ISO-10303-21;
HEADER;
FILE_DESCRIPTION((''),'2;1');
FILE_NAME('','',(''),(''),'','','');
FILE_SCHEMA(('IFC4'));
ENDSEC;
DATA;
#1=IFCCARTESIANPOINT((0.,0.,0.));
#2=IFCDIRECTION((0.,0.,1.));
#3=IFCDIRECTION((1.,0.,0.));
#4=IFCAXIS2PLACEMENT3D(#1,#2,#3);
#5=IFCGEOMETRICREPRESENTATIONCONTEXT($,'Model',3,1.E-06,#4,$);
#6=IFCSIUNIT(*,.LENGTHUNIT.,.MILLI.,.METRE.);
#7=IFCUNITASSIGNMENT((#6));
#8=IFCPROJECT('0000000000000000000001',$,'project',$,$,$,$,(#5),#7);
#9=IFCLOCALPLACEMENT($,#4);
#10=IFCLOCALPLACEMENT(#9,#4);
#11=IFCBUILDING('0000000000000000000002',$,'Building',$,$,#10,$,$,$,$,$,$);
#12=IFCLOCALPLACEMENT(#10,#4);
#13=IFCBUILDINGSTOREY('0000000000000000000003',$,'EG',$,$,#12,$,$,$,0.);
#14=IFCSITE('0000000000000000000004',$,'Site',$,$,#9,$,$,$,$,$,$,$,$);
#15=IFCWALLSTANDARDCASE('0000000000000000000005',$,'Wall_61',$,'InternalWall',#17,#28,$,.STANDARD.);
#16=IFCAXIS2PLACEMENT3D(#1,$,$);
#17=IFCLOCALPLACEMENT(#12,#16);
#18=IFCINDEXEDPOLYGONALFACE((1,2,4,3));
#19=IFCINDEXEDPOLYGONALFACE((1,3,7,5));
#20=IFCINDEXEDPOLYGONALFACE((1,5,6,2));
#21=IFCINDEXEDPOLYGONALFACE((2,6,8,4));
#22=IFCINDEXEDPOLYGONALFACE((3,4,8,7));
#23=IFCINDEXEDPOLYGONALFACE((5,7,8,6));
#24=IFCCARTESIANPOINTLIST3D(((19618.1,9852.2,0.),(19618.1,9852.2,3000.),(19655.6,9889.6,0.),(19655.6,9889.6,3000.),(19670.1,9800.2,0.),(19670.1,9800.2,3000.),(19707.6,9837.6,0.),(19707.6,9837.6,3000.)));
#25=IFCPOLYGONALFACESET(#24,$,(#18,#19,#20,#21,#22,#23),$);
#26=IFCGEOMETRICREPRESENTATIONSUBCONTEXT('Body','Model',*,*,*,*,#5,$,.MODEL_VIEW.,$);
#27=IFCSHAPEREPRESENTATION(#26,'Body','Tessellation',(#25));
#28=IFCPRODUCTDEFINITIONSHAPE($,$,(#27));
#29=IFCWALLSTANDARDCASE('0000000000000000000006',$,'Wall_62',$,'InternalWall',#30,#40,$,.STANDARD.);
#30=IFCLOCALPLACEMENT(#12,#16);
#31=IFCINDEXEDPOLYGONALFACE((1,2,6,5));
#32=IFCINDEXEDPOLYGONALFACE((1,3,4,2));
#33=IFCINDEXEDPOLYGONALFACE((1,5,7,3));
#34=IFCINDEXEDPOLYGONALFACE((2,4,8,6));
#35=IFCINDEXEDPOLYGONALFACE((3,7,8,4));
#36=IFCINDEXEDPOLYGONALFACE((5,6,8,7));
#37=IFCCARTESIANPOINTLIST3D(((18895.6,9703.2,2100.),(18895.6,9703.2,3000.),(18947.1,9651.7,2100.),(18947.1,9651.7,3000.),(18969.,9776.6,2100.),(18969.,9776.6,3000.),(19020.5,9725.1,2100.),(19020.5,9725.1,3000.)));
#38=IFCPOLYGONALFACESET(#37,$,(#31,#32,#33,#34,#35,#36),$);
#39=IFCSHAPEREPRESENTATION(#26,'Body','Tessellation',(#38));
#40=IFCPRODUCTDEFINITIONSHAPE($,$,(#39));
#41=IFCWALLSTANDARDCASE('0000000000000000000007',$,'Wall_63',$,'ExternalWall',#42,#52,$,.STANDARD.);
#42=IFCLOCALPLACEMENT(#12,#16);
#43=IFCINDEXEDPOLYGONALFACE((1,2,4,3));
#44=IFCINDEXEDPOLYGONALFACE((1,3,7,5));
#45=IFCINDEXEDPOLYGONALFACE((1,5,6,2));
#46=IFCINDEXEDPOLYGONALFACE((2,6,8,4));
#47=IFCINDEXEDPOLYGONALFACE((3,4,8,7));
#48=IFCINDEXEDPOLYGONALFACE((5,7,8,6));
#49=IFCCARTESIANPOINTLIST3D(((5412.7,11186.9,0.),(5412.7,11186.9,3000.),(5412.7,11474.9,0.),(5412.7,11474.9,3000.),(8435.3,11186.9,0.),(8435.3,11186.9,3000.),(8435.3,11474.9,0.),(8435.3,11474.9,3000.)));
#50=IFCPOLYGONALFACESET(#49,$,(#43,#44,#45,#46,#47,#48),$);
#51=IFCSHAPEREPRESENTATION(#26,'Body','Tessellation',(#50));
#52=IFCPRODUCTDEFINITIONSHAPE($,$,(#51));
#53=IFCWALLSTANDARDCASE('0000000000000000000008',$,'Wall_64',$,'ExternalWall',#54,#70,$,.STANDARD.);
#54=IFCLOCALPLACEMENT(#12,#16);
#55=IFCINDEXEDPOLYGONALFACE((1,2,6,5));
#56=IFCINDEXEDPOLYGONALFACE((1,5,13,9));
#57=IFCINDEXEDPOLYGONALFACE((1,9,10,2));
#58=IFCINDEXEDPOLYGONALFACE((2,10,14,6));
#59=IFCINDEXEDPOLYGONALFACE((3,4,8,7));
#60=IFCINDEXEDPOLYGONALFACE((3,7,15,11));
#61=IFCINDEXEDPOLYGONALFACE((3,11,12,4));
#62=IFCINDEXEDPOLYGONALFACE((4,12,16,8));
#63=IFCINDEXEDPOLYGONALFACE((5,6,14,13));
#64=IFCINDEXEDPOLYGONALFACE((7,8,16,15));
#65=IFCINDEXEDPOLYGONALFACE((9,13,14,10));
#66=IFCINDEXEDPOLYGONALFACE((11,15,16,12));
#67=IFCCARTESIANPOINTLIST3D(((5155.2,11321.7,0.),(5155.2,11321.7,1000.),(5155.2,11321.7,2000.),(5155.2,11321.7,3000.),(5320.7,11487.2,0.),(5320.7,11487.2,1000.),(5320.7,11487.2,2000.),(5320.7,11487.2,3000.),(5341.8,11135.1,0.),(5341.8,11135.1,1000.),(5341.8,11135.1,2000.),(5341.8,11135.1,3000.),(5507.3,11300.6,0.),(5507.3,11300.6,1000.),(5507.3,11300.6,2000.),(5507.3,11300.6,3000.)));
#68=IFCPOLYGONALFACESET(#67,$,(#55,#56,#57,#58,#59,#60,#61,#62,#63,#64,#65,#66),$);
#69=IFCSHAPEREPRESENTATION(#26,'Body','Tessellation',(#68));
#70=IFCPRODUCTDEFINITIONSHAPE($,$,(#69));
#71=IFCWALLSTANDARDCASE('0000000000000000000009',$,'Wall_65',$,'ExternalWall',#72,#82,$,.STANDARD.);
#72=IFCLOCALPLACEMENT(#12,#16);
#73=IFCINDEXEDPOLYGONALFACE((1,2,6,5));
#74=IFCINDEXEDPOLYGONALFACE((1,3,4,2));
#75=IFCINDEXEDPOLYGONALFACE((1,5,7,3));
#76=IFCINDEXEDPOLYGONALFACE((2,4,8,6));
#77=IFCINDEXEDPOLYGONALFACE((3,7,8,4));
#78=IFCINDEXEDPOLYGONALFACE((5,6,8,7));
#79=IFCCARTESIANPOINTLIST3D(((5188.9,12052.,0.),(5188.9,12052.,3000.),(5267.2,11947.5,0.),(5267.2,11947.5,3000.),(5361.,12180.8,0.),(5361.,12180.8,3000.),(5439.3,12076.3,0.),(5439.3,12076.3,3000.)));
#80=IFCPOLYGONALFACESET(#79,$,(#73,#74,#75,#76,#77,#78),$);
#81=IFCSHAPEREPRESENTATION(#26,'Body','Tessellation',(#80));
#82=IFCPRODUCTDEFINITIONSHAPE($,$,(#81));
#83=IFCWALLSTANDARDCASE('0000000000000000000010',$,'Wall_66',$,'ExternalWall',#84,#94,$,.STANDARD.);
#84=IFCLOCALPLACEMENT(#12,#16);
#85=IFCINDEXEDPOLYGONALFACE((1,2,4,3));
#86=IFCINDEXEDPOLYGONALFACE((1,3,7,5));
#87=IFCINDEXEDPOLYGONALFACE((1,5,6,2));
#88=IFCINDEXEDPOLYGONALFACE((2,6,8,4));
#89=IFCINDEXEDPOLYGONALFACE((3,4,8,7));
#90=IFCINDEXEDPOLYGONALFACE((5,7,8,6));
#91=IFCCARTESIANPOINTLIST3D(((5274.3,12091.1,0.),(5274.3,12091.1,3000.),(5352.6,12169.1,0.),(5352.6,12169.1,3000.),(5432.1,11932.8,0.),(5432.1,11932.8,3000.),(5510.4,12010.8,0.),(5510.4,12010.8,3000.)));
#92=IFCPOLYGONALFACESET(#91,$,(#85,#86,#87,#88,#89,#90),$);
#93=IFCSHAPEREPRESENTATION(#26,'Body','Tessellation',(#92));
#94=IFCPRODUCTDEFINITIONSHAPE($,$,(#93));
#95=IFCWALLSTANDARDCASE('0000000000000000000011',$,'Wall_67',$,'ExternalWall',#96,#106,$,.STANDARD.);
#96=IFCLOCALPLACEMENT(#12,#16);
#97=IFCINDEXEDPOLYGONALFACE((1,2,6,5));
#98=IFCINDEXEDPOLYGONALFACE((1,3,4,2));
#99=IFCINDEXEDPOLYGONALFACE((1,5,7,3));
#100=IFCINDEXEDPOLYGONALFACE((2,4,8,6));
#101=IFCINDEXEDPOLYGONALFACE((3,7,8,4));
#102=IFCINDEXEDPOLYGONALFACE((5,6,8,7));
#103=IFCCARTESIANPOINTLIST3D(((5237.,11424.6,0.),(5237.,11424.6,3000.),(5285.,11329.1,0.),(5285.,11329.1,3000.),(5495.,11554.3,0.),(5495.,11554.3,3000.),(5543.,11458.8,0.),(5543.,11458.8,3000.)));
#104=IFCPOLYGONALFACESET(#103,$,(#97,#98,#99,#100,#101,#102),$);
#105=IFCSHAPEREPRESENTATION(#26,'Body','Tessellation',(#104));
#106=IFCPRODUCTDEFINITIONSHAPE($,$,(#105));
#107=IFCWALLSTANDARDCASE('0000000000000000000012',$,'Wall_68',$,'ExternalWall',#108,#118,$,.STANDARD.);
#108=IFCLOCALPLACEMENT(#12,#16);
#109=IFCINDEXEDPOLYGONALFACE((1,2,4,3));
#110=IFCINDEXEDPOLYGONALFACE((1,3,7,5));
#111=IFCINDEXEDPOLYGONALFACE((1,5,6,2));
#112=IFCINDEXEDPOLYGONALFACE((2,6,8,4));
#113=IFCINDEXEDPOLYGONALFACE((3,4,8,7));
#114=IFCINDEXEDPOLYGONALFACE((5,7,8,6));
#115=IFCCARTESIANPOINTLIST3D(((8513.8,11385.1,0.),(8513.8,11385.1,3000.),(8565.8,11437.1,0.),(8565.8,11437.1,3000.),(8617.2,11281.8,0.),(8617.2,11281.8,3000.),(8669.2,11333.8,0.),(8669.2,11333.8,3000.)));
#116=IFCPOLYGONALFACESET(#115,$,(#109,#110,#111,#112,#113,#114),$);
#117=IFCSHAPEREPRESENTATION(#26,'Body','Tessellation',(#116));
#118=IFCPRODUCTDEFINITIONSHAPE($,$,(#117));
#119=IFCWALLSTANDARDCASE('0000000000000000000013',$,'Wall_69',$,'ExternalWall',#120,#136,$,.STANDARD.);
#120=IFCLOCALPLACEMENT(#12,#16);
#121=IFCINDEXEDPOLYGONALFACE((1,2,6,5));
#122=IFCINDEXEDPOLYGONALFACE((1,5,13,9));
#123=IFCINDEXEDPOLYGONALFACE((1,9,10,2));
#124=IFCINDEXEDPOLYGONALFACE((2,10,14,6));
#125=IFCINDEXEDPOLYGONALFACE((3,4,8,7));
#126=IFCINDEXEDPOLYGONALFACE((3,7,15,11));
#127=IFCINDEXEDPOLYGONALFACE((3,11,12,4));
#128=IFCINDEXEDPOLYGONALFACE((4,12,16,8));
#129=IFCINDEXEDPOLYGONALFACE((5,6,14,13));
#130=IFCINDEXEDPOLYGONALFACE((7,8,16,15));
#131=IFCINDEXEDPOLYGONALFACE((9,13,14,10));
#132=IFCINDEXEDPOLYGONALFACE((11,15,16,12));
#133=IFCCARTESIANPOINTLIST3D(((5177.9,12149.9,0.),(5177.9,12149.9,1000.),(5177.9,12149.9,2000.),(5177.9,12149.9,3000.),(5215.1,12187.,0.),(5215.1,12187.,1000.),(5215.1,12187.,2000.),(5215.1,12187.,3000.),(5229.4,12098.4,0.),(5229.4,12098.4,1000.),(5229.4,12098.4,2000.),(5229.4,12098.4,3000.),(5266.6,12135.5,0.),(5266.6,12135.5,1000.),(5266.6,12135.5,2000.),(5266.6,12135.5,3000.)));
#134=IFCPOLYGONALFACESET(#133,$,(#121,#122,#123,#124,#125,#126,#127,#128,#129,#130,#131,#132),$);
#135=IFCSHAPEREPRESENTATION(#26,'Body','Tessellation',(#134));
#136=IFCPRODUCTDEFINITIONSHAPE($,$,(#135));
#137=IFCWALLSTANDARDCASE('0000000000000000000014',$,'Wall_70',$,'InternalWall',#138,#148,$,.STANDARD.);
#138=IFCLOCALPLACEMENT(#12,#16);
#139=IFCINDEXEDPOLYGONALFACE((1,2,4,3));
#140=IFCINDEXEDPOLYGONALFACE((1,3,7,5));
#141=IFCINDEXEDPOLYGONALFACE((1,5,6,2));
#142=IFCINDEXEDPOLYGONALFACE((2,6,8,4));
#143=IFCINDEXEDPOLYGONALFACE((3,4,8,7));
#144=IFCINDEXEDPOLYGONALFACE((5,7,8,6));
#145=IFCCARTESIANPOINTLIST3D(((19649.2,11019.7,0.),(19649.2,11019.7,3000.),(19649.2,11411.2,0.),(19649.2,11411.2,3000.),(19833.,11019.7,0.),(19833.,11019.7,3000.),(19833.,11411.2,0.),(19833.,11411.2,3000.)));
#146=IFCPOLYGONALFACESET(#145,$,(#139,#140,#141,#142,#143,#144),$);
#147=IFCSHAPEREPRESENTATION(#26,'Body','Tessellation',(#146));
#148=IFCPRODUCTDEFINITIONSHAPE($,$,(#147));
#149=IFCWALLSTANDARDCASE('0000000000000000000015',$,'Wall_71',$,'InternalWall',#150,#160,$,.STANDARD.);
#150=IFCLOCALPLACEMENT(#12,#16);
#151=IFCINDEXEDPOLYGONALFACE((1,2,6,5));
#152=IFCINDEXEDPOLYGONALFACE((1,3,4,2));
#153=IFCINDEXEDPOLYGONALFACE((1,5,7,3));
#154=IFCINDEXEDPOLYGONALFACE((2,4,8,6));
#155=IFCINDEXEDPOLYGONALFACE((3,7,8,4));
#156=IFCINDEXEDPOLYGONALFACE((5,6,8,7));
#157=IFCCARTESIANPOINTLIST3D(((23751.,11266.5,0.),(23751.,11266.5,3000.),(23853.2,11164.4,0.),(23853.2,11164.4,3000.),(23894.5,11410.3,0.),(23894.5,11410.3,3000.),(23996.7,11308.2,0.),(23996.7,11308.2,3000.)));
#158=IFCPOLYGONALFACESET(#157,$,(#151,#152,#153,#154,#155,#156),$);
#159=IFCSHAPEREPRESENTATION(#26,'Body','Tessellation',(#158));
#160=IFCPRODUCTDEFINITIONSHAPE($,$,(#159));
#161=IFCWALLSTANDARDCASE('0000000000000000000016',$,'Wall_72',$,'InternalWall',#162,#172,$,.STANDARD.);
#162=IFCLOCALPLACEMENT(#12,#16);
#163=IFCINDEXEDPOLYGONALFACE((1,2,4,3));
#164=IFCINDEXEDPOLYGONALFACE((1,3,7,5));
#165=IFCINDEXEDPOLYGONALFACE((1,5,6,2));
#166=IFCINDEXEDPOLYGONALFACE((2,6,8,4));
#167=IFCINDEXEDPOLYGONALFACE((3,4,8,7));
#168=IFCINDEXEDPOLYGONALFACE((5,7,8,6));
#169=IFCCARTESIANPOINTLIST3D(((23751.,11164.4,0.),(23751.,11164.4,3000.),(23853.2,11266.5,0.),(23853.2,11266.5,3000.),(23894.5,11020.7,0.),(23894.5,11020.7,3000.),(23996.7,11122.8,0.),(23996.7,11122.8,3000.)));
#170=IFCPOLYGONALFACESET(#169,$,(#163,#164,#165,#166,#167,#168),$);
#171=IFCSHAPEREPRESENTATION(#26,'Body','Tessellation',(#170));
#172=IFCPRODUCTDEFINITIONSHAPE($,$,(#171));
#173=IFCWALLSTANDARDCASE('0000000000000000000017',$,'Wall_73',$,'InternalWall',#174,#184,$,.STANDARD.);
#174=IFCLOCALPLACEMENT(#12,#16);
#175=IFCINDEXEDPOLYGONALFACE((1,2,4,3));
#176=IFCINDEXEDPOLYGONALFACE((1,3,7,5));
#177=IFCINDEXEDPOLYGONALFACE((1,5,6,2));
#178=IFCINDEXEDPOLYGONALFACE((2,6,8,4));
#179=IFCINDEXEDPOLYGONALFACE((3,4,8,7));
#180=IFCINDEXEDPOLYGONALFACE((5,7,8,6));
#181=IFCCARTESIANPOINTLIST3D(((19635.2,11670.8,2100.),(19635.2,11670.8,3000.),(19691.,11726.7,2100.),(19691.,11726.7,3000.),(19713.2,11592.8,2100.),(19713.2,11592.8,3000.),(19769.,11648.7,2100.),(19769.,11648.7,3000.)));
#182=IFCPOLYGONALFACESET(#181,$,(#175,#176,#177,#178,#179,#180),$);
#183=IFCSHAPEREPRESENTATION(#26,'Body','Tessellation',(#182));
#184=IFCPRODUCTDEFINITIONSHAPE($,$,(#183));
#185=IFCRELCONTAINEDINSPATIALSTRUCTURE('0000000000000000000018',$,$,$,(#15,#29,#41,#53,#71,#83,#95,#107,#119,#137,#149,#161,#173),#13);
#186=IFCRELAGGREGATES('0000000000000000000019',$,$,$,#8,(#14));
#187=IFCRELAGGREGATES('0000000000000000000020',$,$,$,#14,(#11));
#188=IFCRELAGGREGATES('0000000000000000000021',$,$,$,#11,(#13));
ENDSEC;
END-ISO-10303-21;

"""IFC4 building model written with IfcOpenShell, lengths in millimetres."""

from ifc_helpers import new_model, si_unit, frame, origin_with_axes, place, context, subcontext, project, spatial, rectangle, extrude, element, save


model = new_model("IFC4")

# Units and contexts
model_context = context("Model", 3, precision=1e-06, world=origin_with_axes())
body_context = subcontext(model_context, "Body", "Model", "MODEL_VIEW")
ifc_project = project(units=[si_unit("LENGTHUNIT", "METRE", prefix="MILLI")], contexts=[model_context])

# Site, building, storey
site_placement = place(None, origin_with_axes())
site = spatial("IfcSite", under=ifc_project, at=site_placement, Name="Site")
building_placement = place(site_placement, origin_with_axes())
building = spatial("IfcBuilding", under=site, at=building_placement, Name="Building")
storey_placement = place(building_placement, origin_with_axes())
storey = spatial("IfcBuildingStorey", under=building, at=storey_placement, Name="EG", Elevation=0.0)

# Wall
wall_1_placement = place(storey_placement, origin_with_axes())
element("IfcWallStandardCase", 1, at=wall_1_placement, inside=storey, Name="Wall_61", ObjectType="InternalWall", PredefinedType="STANDARD", context=body_context, shape_type="SweptSolid", body=[
    extrude(rectangle(XDim=73.5, YDim=53.0), frame((19662.8, 9844.9, 0.0), z_axis=(0.0, 0.0, 1.0), x_axis=(0.707107, -0.707107, 0.0)), (0.0, 0.0, 1.0), 3000.0),
])

# Wall, opening
wall_2_placement = place(storey_placement, origin_with_axes())
wall_2 = element("IfcWallStandardCase", 2, at=wall_2_placement, inside=storey, Name="Wall_62", ObjectType="InternalWall", PredefinedType="STANDARD", context=body_context, shape_type="SweptSolid", body=[
    extrude(rectangle(XDim=72.8, YDim=103.8), frame((18958.1, 9714.2, 0.0), z_axis=(0.0, 0.0, 1.0), x_axis=(0.707107, -0.707107, 0.0)), (0.0, 0.0, 1.0), 3000.0),
])
opening_1_placement = place(wall_2_placement, origin_with_axes())
element("IfcOpeningElement", 3, at=opening_1_placement, inside=storey, cuts=wall_2, context=body_context, shape_type="SweptSolid", body=[
    extrude(rectangle(XDim=450.0, YDim=103.8), frame((18958.1, 9714.2, 0.0), z_axis=(0.0, 0.0, 1.0), x_axis=(0.707107, -0.707107, 0.0)), (0.0, 0.0, 1.0), 2100.0),
])

# Wall
wall_3_placement = place(storey_placement, origin_with_axes())
element("IfcWallStandardCase", 4, at=wall_3_placement, inside=storey, Name="Wall_63", ObjectType="ExternalWall", PredefinedType="STANDARD", context=body_context, shape_type="SweptSolid", body=[
    extrude(rectangle(XDim=3022.6, YDim=288.0), frame((6924.0, 11330.9, 0.0), z_axis=(0.0, 0.0, 1.0), x_axis=(1.0, 0.0, 0.0)), (0.0, 0.0, 1.0), 3000.0),
])

# Wall, opening
wall_4_placement = place(storey_placement, origin_with_axes())
wall_4 = element("IfcWallStandardCase", 5, at=wall_4_placement, inside=storey, Name="Wall_64", ObjectType="ExternalWall", PredefinedType="STANDARD", context=body_context, shape_type="SweptSolid", body=[
    extrude(rectangle(XDim=234.1, YDim=263.9), frame((5331.2, 11311.2, 0.0), z_axis=(0.0, 0.0, 1.0), x_axis=(-0.707107, -0.707107, 0.0)), (0.0, 0.0, 1.0), 3000.0),
])
opening_2_placement = place(wall_4_placement, origin_with_axes())
element("IfcOpeningElement", 6, at=opening_2_placement, inside=storey, cuts=wall_4, context=body_context, shape_type="SweptSolid", body=[
    extrude(rectangle(XDim=600.0, YDim=263.9), frame((5268.2, 11248.1, 1000.0), z_axis=(0.0, 0.0, 1.0), x_axis=(-0.707107, -0.707107, 0.0)), (0.0, 0.0, 1.0), 1000.0),
])

# Walls
wall_5_placement = place(storey_placement, origin_with_axes())
element("IfcWallStandardCase", 7, at=wall_5_placement, inside=storey, Name="Wall_65", ObjectType="ExternalWall", PredefinedType="STANDARD", context=body_context, shape_type="SweptSolid", body=[
    extrude(rectangle(XDim=130.6, YDim=215.0), frame((5314.1, 12064.2, 0.0), z_axis=(0.0, 0.0, 1.0), x_axis=(-0.599387, 0.800459, 0.0)), (0.0, 0.0, 1.0), 3000.0),
])
wall_6_placement = place(storey_placement, origin_with_axes())
element("IfcWallStandardCase", 8, at=wall_6_placement, inside=storey, Name="Wall_66", ObjectType="ExternalWall", PredefinedType="STANDARD", context=body_context, shape_type="SweptSolid", body=[
    extrude(rectangle(XDim=110.5, YDim=223.5), frame((5392.4, 12050.9, 0.0), z_axis=(0.0, 0.0, 1.0), x_axis=(0.708237, 0.705975, 0.0)), (0.0, 0.0, 1.0), 3000.0),
])
wall_7_placement = place(storey_placement, origin_with_axes())
element("IfcWallStandardCase", 9, at=wall_7_placement, inside=storey, Name="Wall_67", ObjectType="ExternalWall", PredefinedType="STANDARD", context=body_context, shape_type="SweptSolid", body=[
    extrude(rectangle(XDim=106.9, YDim=288.8), frame((5390.0, 11441.7, 0.0), z_axis=(0.0, 0.0, 1.0), x_axis=(0.449084, -0.89349, 0.0)), (0.0, 0.0, 1.0), 3000.0),
])
wall_8_placement = place(storey_placement, origin_with_axes())
element("IfcWallStandardCase", 10, at=wall_8_placement, inside=storey, Name="Wall_68", ObjectType="ExternalWall", PredefinedType="STANDARD", context=body_context, shape_type="SweptSolid", body=[
    extrude(rectangle(XDim=73.5, YDim=146.1), frame((8591.5, 11359.4, 0.0), z_axis=(0.0, 0.0, 1.0), x_axis=(-0.707107, -0.707107, 0.0)), (0.0, 0.0, 1.0), 3000.0),
])

# Wall, opening
wall_9_placement = place(storey_placement, origin_with_axes())
wall_9 = element("IfcWallStandardCase", 11, at=wall_9_placement, inside=storey, Name="Wall_69", ObjectType="ExternalWall", PredefinedType="STANDARD", context=body_context, shape_type="SweptSolid", body=[
    extrude(rectangle(XDim=72.8, YDim=52.5), frame((5222.2, 12142.7, 0.0), z_axis=(0.0, 0.0, 1.0), x_axis=(0.707107, -0.707107, 0.0)), (0.0, 0.0, 1.0), 3000.0),
])
opening_3_placement = place(wall_9_placement, origin_with_axes())
element("IfcOpeningElement", 12, at=opening_3_placement, inside=storey, cuts=wall_9, context=body_context, shape_type="SweptSolid", body=[
    extrude(rectangle(XDim=600.0, YDim=52.5), frame((5222.2, 12142.7, 1000.0), z_axis=(0.0, 0.0, 1.0), x_axis=(0.707107, -0.707107, 0.0)), (0.0, 0.0, 1.0), 1000.0),
])

# Walls
wall_10_placement = place(storey_placement, origin_with_axes())
element("IfcWallStandardCase", 13, at=wall_10_placement, inside=storey, Name="Wall_70", ObjectType="InternalWall", PredefinedType="STANDARD", context=body_context, shape_type="SweptSolid", body=[
    extrude(rectangle(XDim=391.5, YDim=183.7), frame((19741.1, 11215.5, 0.0), z_axis=(0.0, 0.0, 1.0), x_axis=(0.0, -1.0, 0.0)), (0.0, 0.0, 1.0), 3000.0),
])
wall_11_placement = place(storey_placement, origin_with_axes())
element("IfcWallStandardCase", 14, at=wall_11_placement, inside=storey, Name="Wall_71", ObjectType="InternalWall", PredefinedType="STANDARD", context=body_context, shape_type="SweptSolid", body=[
    extrude(rectangle(XDim=203.1, YDim=144.5), frame((23873.9, 11287.4, 0.0), z_axis=(0.0, 0.0, 1.0), x_axis=(0.706491, 0.707722, 0.0)), (0.0, 0.0, 1.0), 3000.0),
])
wall_12_placement = place(storey_placement, origin_with_axes())
element("IfcWallStandardCase", 15, at=wall_12_placement, inside=storey, Name="Wall_72", ObjectType="InternalWall", PredefinedType="STANDARD", context=body_context, shape_type="SweptSolid", body=[
    extrude(rectangle(XDim=203.1, YDim=144.5), frame((23873.9, 11143.6, 0.0), z_axis=(0.0, 0.0, 1.0), x_axis=(0.706491, -0.707722, 0.0)), (0.0, 0.0, 1.0), 3000.0),
])

# Wall, opening
wall_13_placement = place(storey_placement, origin_with_axes())
wall_13 = element("IfcWallStandardCase", 16, at=wall_13_placement, inside=storey, Name="Wall_73", ObjectType="InternalWall", PredefinedType="STANDARD", context=body_context, shape_type="SweptSolid", body=[
    extrude(rectangle(XDim=110.3, YDim=79.0), frame((19702.1, 11659.7, 0.0), z_axis=(0.0, 0.0, 1.0), x_axis=(-0.707107, 0.707107, 0.0)), (0.0, 0.0, 1.0), 3000.0),
])
opening_4_placement = place(wall_13_placement, origin_with_axes())
element("IfcOpeningElement", 17, at=opening_4_placement, inside=storey, cuts=wall_13, context=body_context, shape_type="SweptSolid", body=[
    extrude(rectangle(XDim=450.0, YDim=79.0), frame((19702.1, 11659.7, 0.0), z_axis=(0.0, 0.0, 1.0), x_axis=(-0.707107, 0.707107, 0.0)), (0.0, 0.0, 1.0), 2100.0),
])

save(model, "model.ifc")
